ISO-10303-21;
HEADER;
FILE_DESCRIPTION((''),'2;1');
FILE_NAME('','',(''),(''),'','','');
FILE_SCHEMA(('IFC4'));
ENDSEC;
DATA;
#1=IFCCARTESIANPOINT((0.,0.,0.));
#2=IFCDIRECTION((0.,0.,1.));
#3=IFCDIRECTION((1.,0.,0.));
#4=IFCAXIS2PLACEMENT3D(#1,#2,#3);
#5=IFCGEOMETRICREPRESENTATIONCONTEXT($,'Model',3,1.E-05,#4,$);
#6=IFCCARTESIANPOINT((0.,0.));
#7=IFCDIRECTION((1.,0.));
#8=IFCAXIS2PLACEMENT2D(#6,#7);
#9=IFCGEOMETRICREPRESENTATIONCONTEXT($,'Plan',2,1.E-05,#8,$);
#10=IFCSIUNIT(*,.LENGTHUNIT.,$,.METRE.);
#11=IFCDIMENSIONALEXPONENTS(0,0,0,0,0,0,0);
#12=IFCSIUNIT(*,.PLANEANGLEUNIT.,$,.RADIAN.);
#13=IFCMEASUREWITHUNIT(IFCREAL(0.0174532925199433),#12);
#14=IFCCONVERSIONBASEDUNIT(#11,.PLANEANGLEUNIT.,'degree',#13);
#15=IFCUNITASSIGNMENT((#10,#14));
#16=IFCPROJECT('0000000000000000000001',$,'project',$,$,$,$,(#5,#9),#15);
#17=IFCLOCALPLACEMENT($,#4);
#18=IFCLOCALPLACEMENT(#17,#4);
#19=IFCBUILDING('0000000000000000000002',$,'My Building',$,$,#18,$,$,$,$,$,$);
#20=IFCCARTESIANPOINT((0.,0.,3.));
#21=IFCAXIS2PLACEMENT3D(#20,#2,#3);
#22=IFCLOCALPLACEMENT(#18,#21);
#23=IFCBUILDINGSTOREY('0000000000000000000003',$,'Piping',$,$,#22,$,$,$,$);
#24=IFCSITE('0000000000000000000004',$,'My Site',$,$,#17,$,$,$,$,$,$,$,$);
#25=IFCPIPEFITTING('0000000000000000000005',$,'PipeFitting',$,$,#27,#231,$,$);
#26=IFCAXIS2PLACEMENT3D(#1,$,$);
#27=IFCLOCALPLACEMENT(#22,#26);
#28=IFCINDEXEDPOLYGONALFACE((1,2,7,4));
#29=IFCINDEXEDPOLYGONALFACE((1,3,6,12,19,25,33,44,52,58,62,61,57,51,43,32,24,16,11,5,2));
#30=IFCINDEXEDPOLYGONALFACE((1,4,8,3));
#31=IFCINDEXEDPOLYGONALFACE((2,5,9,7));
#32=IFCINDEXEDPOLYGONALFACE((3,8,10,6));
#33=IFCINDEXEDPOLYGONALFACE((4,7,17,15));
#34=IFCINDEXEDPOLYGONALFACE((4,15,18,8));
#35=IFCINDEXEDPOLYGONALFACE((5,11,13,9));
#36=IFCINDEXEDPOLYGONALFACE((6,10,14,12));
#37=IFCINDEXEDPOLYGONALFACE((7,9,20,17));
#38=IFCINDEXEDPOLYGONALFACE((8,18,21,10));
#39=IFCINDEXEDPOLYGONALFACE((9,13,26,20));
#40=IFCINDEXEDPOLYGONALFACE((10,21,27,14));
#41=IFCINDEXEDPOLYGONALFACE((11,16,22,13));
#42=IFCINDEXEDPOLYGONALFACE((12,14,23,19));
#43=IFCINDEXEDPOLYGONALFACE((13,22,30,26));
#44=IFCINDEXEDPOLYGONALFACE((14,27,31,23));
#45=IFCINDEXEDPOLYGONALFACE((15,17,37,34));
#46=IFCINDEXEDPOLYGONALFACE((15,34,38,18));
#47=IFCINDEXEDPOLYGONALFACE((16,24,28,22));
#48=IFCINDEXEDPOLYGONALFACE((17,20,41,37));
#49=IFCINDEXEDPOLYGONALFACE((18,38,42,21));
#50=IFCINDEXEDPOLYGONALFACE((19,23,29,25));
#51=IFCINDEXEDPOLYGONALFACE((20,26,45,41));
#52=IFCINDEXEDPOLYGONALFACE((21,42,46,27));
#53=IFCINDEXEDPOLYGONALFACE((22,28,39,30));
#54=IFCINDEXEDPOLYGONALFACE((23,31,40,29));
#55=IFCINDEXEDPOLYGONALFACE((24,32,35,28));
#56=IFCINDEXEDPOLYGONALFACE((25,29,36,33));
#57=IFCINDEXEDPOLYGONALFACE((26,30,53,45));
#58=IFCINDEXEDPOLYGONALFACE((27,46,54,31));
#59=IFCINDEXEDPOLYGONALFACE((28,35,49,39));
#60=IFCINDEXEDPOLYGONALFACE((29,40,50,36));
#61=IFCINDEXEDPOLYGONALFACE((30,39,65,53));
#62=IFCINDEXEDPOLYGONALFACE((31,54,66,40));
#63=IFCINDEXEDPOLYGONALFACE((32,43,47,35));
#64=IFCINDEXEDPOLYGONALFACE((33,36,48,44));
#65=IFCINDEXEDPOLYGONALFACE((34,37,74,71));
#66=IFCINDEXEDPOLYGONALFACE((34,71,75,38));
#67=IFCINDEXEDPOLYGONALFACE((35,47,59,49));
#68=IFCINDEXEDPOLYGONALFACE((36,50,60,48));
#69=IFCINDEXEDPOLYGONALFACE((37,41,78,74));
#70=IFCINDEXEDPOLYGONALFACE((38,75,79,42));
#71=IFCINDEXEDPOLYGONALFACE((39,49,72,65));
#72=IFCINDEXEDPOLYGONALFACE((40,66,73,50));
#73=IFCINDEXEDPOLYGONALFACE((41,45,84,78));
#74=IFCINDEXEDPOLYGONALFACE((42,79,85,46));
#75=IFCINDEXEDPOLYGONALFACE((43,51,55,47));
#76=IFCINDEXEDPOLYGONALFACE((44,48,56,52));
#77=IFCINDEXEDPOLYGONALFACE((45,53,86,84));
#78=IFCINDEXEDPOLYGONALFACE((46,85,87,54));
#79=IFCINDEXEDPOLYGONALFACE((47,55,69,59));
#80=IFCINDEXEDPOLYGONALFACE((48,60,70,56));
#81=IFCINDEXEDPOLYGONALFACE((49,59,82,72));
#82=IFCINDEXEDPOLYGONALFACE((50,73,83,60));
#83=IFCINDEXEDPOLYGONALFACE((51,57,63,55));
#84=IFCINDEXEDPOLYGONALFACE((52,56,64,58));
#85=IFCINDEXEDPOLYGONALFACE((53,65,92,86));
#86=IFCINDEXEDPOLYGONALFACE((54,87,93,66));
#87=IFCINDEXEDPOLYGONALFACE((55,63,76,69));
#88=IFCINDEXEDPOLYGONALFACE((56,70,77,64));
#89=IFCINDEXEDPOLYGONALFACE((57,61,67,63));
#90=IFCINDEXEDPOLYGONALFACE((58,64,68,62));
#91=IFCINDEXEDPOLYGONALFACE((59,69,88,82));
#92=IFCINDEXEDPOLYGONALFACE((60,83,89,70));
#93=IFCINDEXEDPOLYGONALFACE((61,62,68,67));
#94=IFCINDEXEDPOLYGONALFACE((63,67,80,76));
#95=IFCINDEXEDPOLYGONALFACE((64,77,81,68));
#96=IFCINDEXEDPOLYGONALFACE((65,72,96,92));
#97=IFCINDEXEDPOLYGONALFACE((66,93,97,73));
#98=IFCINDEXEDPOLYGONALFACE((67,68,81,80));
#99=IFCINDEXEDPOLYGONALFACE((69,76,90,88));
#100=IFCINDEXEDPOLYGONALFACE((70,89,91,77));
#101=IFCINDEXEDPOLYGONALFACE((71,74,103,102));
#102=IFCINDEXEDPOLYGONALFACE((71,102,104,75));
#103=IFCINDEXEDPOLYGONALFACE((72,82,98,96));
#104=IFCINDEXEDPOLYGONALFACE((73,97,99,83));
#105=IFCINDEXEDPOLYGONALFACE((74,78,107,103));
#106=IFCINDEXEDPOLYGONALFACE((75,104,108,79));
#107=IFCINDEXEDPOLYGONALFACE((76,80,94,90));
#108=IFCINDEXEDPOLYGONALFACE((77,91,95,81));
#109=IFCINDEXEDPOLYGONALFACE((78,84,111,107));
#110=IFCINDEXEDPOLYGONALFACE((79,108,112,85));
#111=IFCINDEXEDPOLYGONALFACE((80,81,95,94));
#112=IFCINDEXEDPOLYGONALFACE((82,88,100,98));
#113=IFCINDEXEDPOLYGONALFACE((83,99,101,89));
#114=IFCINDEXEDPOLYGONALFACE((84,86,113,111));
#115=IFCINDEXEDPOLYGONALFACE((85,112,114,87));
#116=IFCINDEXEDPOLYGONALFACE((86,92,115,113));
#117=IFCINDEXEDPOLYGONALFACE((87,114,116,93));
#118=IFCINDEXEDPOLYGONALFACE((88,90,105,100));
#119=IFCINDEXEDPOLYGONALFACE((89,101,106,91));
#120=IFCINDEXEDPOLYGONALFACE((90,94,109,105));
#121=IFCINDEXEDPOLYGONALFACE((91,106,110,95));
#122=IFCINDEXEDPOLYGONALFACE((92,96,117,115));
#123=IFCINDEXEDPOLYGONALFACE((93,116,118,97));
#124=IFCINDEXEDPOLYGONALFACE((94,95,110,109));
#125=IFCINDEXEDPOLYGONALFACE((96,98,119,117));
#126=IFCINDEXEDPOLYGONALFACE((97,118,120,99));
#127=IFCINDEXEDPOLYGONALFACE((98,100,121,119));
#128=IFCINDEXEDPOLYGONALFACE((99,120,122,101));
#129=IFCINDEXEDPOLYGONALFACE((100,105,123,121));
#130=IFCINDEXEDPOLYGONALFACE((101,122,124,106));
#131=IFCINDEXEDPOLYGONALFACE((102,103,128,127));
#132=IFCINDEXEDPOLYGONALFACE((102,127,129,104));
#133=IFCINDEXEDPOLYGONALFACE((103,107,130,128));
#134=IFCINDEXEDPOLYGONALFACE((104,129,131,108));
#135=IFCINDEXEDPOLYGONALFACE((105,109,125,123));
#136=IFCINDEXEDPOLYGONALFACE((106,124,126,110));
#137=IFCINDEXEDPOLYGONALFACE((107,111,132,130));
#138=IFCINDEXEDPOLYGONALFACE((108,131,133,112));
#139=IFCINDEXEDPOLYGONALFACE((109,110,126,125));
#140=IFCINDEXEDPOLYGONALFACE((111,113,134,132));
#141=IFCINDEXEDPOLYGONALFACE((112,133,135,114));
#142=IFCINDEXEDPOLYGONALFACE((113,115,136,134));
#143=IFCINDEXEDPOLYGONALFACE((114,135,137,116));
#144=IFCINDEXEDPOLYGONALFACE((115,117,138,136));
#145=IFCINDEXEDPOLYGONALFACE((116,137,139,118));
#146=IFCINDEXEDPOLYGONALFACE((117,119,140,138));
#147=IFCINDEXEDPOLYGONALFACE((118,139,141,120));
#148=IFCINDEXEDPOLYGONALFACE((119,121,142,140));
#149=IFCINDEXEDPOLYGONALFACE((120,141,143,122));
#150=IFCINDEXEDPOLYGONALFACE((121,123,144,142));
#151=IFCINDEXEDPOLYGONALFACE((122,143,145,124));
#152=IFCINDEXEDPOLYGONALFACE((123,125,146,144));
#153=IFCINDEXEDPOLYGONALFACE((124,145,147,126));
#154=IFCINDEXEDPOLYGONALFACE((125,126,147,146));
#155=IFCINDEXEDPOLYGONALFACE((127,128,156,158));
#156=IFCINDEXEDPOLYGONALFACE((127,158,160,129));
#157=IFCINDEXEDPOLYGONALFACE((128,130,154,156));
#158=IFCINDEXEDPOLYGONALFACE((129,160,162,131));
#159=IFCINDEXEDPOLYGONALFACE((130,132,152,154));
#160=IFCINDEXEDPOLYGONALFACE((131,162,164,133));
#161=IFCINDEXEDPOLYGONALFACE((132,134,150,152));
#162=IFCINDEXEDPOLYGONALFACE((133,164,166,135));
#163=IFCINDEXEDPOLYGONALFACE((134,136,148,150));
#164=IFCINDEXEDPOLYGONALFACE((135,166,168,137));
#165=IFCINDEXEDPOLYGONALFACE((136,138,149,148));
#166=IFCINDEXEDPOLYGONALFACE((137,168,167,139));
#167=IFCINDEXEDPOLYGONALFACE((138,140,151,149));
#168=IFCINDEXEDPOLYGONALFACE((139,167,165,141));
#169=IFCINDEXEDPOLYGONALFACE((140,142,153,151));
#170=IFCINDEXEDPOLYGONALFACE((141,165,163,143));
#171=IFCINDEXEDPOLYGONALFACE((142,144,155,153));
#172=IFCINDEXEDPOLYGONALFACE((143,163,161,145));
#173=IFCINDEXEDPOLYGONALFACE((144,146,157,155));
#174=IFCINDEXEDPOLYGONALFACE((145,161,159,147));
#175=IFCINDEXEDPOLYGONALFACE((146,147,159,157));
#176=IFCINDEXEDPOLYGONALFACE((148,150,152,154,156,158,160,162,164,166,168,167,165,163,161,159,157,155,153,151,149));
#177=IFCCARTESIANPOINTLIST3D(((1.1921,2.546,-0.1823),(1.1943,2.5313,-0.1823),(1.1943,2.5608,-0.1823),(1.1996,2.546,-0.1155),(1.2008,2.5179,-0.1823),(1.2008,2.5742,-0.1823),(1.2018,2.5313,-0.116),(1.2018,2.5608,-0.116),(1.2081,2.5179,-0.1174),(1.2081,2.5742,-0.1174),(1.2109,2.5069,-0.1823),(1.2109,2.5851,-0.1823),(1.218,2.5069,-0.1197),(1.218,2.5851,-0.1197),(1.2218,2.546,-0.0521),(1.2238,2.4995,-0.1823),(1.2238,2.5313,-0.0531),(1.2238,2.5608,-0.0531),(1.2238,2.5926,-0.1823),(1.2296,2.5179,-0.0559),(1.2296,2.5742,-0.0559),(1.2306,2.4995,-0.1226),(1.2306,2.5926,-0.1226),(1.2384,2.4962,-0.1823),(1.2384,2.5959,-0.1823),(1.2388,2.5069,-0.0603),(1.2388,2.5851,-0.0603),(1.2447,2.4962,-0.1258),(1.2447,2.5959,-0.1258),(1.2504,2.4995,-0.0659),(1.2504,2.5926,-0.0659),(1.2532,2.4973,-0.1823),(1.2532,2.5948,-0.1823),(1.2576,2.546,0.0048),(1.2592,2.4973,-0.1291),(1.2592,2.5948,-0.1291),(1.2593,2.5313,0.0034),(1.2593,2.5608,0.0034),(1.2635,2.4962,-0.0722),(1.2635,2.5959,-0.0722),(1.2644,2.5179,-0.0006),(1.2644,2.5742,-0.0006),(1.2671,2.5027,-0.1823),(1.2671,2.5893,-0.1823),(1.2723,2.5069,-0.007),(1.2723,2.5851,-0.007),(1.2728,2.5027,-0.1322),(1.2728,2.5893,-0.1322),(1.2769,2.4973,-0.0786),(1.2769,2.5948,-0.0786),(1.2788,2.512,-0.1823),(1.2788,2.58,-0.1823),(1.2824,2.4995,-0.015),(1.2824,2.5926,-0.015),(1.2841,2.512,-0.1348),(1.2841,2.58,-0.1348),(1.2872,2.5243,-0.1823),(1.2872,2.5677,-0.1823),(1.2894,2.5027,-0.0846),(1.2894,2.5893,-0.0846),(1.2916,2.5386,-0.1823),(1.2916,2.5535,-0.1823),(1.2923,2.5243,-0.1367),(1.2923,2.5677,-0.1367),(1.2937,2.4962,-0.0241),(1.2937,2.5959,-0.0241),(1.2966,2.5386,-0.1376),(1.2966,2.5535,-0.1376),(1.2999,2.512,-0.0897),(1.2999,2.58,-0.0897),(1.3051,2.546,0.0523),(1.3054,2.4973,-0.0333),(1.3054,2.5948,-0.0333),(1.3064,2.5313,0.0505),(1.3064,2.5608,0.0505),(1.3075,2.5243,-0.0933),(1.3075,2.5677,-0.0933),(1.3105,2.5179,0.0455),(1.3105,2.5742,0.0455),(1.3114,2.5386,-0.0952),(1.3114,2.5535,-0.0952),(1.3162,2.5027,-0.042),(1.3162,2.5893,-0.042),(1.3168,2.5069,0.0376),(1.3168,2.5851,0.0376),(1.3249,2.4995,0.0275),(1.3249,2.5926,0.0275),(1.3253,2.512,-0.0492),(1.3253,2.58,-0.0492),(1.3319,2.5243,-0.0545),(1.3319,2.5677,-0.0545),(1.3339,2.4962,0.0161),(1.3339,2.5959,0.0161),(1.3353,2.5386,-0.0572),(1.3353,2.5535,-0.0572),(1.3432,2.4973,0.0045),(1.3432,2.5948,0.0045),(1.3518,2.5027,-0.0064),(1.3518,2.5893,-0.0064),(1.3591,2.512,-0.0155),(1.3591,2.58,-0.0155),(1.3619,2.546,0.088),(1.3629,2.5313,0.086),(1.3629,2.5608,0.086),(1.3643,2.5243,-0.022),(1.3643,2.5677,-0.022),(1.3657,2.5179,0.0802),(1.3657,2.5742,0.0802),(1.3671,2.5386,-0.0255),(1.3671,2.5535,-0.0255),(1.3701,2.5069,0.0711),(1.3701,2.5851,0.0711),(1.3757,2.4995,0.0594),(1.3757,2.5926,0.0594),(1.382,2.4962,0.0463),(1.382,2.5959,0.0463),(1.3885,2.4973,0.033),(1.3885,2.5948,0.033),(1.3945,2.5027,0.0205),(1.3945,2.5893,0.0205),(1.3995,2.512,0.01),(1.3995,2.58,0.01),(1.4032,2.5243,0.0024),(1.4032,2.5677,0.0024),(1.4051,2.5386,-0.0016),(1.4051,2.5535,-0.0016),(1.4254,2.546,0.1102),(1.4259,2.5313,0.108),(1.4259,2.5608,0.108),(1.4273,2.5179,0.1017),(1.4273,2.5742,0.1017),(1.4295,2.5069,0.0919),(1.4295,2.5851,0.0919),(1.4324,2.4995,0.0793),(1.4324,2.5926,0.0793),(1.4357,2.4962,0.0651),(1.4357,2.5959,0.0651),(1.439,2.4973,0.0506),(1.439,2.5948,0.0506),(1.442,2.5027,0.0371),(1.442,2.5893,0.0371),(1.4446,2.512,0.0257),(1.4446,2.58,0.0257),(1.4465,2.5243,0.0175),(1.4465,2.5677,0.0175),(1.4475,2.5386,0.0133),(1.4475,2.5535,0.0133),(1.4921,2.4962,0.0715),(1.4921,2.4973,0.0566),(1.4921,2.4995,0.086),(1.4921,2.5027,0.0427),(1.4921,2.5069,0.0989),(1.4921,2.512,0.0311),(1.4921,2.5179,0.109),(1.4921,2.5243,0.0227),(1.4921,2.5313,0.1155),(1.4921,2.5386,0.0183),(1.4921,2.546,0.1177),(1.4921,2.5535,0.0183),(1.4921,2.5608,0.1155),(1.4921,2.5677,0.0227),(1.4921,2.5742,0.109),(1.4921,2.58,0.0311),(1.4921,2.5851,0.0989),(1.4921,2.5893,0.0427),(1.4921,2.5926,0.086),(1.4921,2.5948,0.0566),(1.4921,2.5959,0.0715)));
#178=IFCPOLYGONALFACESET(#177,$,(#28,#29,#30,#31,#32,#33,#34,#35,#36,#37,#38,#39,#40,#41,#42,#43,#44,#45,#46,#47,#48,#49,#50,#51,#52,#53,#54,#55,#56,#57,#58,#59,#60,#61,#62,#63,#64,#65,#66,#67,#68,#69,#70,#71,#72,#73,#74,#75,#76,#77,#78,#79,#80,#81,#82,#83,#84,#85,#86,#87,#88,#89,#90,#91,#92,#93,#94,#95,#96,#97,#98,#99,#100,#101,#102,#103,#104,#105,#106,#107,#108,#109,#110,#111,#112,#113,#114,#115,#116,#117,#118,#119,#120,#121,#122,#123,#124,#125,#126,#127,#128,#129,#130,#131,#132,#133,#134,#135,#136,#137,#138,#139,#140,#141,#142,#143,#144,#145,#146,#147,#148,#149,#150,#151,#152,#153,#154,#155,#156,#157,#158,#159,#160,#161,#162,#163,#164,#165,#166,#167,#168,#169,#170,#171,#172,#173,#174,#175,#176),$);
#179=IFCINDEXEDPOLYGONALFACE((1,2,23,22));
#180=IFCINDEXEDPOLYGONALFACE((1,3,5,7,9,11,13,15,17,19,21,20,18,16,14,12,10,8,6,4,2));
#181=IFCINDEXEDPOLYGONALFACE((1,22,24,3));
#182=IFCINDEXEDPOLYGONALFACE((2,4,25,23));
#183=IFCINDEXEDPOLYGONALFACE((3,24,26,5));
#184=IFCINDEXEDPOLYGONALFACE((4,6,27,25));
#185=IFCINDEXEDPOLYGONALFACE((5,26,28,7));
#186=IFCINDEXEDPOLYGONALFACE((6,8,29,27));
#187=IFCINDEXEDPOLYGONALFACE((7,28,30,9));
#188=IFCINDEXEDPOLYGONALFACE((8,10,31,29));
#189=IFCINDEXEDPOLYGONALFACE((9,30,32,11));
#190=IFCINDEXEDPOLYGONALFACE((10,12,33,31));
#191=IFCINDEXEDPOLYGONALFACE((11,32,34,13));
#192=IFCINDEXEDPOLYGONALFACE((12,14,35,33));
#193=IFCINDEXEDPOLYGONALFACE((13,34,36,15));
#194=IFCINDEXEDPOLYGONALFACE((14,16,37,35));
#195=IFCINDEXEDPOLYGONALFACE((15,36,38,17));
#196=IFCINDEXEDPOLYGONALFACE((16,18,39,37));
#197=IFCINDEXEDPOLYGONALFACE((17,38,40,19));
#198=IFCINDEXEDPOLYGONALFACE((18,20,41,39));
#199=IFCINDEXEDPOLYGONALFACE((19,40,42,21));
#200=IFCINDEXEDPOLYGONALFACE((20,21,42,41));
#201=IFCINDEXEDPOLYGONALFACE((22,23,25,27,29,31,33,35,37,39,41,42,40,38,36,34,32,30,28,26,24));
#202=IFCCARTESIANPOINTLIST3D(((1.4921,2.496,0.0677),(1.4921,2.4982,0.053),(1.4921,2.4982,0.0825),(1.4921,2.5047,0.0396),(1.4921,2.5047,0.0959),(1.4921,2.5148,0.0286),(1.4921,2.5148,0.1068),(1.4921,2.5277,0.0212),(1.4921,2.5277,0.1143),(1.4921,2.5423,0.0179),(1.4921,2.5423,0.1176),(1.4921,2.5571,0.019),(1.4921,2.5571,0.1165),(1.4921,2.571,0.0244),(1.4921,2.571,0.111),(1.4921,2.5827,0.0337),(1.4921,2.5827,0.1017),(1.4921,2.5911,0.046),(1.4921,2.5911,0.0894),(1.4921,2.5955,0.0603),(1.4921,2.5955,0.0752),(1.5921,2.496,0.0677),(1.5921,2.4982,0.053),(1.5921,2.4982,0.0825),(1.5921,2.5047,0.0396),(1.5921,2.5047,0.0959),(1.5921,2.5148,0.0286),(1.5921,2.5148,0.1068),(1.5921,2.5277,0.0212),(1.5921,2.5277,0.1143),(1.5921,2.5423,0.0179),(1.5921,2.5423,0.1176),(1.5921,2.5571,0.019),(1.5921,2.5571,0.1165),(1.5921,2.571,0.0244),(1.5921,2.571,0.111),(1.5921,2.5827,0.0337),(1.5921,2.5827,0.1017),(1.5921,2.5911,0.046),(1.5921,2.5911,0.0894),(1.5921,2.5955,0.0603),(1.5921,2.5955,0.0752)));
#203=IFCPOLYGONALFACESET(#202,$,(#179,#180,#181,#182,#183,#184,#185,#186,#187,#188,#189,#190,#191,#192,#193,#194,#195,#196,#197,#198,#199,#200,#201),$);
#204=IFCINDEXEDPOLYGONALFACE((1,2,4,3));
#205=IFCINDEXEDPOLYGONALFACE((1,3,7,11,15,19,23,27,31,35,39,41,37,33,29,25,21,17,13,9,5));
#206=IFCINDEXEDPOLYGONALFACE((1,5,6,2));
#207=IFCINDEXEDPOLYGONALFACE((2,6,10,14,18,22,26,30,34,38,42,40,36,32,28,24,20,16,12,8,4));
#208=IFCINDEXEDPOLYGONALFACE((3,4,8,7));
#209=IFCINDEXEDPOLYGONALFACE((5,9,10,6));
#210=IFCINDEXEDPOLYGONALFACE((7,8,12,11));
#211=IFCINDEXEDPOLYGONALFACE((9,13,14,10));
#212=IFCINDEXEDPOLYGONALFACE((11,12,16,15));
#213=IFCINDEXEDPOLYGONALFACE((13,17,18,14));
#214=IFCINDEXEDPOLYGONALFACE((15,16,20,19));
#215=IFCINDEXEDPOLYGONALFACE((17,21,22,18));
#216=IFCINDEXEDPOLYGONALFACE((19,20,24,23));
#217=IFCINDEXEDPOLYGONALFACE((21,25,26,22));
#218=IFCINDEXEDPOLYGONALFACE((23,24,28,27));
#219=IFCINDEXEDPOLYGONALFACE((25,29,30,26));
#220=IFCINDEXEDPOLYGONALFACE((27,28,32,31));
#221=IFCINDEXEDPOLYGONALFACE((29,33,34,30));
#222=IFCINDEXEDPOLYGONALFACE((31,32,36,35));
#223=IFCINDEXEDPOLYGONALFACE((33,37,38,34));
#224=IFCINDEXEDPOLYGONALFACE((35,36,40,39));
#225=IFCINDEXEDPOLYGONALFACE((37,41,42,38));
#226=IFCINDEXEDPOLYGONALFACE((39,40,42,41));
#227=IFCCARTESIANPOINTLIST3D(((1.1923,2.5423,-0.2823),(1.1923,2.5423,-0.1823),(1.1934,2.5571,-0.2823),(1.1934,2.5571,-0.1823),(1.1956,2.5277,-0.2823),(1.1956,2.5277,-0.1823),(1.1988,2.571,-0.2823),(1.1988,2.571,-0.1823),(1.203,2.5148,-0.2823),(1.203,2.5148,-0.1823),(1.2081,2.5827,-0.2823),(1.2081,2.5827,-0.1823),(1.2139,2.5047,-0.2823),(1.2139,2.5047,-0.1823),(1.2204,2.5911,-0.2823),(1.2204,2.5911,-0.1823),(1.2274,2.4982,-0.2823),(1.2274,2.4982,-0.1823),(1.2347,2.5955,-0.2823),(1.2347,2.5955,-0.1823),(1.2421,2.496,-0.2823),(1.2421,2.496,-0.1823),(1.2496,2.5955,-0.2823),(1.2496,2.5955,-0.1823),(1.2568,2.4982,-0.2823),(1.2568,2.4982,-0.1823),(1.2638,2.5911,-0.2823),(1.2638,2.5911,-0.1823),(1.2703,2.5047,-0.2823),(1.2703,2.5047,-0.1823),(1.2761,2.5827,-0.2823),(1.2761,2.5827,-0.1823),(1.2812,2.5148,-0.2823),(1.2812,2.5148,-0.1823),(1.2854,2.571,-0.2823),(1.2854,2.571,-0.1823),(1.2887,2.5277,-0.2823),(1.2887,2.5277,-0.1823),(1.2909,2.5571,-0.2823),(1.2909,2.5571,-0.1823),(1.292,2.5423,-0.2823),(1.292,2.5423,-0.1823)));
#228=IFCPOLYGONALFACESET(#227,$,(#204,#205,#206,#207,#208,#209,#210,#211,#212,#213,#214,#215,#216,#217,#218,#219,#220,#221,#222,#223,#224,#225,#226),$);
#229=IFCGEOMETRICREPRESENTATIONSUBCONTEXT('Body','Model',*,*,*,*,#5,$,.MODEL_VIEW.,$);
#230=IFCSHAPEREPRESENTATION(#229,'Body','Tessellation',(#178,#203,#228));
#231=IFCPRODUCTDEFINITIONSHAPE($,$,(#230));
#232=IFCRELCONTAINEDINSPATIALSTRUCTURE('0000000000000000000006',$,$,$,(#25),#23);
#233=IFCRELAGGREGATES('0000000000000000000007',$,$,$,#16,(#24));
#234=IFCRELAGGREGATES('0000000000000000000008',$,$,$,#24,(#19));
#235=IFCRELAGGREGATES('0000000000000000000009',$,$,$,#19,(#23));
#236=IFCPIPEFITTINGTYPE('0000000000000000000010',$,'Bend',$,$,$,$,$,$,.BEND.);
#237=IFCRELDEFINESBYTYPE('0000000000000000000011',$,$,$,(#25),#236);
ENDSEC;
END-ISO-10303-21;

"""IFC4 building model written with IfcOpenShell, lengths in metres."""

from ifc_helpers import new_model, entity, si_unit, converted_unit, frame, origin_with_axes, origin_2d_with_axis, place, context, subcontext, project, spatial, circle, extrude, source, transform, mapped, type_object, type_shapes, element, save


model = new_model("IFC4")

# Units and contexts
model_context = context("Model", 3, precision=1e-05, world=origin_with_axes())
plan_context = context("Plan", 2, precision=1e-05, world=origin_2d_with_axis())
body_context = subcontext(model_context, "Body", "Model", "MODEL_VIEW")
ifc_project = project(units=[si_unit("LENGTHUNIT", "METRE"), converted_unit("PLANEANGLEUNIT", "degree", entity("IfcReal", 0.0174532925199433), si_unit("PLANEANGLEUNIT", "RADIAN"), dimensions=[0, 0, 0, 0, 0, 0, 0])], contexts=[model_context, plan_context])

# Site, building, storey
site_placement = place(None, origin_with_axes())
site = spatial("IfcSite", under=ifc_project, at=site_placement, Name="My Site")
building_placement = place(site_placement, origin_with_axes())
building = spatial("IfcBuilding", under=site, at=building_placement, Name="My Building")
storey_placement = place(building_placement, frame((0.0, 0.0, 3.0), z_axis=(0.0, 0.0, 1.0), x_axis=(1.0, 0.0, 0.0)))
storey = spatial("IfcBuildingStorey", under=building, at=storey_placement, Name="Piping")

# Pipe fitting
pipe_fitting_type_1 = type_object("IfcPipeFittingType", Name="Bend", PredefinedType="BEND")
shared_shape = source(origin_with_axes(), body_context, "Body", "SolidModel", [
    entity("IfcSweptDiskSolid", entity("IfcIndexedPolyCurve", entity("IfcCartesianPointList3D", [[0.0, 0.0, 0.1], [0.0, -0.0732, 0.2768], [0.0, -0.25, 0.35]]), [entity("IfcArcIndex", [1, 2, 3])]), 0.05),
    extrude(circle(Radius=0.05), origin_with_axes(), (0.0, 0.0, 1.0), 0.1),
    extrude(circle(Radius=0.05), frame((0.0, -0.25, 0.35), z_axis=(0.0, -1.0, -0.000002), x_axis=(1.0, 0.0, 0.0)), (0.0, 0.0, 1.0), 0.1),
])
type_shapes(pipe_fitting_type_1, [shared_shape])
for number, where, z_axis, x_axis, name in (
    (1, (1.5921, 2.546, 0.0677), (-1.0, 0.0, 0.000002), (0.0, -1.0, 0.0), "PipeFitting"),
):
    element("IfcPipeFitting", number, at=place(storey_placement, frame(where, z_axis=z_axis, x_axis=x_axis)), inside=storey, type_object=pipe_fitting_type_1, Name=name, context=body_context, shape_type="MappedRepresentation", body=[
        mapped(shared_shape, transform((0.0, 0.0, 0.0), x_axis=(1.0, 0.0, 0.0), y_axis=(0.0, 1.0, 0.0), z_axis=(0.0, 0.0, 1.0), scale=1.0)),
    ])

save(model, "model.ifc")
